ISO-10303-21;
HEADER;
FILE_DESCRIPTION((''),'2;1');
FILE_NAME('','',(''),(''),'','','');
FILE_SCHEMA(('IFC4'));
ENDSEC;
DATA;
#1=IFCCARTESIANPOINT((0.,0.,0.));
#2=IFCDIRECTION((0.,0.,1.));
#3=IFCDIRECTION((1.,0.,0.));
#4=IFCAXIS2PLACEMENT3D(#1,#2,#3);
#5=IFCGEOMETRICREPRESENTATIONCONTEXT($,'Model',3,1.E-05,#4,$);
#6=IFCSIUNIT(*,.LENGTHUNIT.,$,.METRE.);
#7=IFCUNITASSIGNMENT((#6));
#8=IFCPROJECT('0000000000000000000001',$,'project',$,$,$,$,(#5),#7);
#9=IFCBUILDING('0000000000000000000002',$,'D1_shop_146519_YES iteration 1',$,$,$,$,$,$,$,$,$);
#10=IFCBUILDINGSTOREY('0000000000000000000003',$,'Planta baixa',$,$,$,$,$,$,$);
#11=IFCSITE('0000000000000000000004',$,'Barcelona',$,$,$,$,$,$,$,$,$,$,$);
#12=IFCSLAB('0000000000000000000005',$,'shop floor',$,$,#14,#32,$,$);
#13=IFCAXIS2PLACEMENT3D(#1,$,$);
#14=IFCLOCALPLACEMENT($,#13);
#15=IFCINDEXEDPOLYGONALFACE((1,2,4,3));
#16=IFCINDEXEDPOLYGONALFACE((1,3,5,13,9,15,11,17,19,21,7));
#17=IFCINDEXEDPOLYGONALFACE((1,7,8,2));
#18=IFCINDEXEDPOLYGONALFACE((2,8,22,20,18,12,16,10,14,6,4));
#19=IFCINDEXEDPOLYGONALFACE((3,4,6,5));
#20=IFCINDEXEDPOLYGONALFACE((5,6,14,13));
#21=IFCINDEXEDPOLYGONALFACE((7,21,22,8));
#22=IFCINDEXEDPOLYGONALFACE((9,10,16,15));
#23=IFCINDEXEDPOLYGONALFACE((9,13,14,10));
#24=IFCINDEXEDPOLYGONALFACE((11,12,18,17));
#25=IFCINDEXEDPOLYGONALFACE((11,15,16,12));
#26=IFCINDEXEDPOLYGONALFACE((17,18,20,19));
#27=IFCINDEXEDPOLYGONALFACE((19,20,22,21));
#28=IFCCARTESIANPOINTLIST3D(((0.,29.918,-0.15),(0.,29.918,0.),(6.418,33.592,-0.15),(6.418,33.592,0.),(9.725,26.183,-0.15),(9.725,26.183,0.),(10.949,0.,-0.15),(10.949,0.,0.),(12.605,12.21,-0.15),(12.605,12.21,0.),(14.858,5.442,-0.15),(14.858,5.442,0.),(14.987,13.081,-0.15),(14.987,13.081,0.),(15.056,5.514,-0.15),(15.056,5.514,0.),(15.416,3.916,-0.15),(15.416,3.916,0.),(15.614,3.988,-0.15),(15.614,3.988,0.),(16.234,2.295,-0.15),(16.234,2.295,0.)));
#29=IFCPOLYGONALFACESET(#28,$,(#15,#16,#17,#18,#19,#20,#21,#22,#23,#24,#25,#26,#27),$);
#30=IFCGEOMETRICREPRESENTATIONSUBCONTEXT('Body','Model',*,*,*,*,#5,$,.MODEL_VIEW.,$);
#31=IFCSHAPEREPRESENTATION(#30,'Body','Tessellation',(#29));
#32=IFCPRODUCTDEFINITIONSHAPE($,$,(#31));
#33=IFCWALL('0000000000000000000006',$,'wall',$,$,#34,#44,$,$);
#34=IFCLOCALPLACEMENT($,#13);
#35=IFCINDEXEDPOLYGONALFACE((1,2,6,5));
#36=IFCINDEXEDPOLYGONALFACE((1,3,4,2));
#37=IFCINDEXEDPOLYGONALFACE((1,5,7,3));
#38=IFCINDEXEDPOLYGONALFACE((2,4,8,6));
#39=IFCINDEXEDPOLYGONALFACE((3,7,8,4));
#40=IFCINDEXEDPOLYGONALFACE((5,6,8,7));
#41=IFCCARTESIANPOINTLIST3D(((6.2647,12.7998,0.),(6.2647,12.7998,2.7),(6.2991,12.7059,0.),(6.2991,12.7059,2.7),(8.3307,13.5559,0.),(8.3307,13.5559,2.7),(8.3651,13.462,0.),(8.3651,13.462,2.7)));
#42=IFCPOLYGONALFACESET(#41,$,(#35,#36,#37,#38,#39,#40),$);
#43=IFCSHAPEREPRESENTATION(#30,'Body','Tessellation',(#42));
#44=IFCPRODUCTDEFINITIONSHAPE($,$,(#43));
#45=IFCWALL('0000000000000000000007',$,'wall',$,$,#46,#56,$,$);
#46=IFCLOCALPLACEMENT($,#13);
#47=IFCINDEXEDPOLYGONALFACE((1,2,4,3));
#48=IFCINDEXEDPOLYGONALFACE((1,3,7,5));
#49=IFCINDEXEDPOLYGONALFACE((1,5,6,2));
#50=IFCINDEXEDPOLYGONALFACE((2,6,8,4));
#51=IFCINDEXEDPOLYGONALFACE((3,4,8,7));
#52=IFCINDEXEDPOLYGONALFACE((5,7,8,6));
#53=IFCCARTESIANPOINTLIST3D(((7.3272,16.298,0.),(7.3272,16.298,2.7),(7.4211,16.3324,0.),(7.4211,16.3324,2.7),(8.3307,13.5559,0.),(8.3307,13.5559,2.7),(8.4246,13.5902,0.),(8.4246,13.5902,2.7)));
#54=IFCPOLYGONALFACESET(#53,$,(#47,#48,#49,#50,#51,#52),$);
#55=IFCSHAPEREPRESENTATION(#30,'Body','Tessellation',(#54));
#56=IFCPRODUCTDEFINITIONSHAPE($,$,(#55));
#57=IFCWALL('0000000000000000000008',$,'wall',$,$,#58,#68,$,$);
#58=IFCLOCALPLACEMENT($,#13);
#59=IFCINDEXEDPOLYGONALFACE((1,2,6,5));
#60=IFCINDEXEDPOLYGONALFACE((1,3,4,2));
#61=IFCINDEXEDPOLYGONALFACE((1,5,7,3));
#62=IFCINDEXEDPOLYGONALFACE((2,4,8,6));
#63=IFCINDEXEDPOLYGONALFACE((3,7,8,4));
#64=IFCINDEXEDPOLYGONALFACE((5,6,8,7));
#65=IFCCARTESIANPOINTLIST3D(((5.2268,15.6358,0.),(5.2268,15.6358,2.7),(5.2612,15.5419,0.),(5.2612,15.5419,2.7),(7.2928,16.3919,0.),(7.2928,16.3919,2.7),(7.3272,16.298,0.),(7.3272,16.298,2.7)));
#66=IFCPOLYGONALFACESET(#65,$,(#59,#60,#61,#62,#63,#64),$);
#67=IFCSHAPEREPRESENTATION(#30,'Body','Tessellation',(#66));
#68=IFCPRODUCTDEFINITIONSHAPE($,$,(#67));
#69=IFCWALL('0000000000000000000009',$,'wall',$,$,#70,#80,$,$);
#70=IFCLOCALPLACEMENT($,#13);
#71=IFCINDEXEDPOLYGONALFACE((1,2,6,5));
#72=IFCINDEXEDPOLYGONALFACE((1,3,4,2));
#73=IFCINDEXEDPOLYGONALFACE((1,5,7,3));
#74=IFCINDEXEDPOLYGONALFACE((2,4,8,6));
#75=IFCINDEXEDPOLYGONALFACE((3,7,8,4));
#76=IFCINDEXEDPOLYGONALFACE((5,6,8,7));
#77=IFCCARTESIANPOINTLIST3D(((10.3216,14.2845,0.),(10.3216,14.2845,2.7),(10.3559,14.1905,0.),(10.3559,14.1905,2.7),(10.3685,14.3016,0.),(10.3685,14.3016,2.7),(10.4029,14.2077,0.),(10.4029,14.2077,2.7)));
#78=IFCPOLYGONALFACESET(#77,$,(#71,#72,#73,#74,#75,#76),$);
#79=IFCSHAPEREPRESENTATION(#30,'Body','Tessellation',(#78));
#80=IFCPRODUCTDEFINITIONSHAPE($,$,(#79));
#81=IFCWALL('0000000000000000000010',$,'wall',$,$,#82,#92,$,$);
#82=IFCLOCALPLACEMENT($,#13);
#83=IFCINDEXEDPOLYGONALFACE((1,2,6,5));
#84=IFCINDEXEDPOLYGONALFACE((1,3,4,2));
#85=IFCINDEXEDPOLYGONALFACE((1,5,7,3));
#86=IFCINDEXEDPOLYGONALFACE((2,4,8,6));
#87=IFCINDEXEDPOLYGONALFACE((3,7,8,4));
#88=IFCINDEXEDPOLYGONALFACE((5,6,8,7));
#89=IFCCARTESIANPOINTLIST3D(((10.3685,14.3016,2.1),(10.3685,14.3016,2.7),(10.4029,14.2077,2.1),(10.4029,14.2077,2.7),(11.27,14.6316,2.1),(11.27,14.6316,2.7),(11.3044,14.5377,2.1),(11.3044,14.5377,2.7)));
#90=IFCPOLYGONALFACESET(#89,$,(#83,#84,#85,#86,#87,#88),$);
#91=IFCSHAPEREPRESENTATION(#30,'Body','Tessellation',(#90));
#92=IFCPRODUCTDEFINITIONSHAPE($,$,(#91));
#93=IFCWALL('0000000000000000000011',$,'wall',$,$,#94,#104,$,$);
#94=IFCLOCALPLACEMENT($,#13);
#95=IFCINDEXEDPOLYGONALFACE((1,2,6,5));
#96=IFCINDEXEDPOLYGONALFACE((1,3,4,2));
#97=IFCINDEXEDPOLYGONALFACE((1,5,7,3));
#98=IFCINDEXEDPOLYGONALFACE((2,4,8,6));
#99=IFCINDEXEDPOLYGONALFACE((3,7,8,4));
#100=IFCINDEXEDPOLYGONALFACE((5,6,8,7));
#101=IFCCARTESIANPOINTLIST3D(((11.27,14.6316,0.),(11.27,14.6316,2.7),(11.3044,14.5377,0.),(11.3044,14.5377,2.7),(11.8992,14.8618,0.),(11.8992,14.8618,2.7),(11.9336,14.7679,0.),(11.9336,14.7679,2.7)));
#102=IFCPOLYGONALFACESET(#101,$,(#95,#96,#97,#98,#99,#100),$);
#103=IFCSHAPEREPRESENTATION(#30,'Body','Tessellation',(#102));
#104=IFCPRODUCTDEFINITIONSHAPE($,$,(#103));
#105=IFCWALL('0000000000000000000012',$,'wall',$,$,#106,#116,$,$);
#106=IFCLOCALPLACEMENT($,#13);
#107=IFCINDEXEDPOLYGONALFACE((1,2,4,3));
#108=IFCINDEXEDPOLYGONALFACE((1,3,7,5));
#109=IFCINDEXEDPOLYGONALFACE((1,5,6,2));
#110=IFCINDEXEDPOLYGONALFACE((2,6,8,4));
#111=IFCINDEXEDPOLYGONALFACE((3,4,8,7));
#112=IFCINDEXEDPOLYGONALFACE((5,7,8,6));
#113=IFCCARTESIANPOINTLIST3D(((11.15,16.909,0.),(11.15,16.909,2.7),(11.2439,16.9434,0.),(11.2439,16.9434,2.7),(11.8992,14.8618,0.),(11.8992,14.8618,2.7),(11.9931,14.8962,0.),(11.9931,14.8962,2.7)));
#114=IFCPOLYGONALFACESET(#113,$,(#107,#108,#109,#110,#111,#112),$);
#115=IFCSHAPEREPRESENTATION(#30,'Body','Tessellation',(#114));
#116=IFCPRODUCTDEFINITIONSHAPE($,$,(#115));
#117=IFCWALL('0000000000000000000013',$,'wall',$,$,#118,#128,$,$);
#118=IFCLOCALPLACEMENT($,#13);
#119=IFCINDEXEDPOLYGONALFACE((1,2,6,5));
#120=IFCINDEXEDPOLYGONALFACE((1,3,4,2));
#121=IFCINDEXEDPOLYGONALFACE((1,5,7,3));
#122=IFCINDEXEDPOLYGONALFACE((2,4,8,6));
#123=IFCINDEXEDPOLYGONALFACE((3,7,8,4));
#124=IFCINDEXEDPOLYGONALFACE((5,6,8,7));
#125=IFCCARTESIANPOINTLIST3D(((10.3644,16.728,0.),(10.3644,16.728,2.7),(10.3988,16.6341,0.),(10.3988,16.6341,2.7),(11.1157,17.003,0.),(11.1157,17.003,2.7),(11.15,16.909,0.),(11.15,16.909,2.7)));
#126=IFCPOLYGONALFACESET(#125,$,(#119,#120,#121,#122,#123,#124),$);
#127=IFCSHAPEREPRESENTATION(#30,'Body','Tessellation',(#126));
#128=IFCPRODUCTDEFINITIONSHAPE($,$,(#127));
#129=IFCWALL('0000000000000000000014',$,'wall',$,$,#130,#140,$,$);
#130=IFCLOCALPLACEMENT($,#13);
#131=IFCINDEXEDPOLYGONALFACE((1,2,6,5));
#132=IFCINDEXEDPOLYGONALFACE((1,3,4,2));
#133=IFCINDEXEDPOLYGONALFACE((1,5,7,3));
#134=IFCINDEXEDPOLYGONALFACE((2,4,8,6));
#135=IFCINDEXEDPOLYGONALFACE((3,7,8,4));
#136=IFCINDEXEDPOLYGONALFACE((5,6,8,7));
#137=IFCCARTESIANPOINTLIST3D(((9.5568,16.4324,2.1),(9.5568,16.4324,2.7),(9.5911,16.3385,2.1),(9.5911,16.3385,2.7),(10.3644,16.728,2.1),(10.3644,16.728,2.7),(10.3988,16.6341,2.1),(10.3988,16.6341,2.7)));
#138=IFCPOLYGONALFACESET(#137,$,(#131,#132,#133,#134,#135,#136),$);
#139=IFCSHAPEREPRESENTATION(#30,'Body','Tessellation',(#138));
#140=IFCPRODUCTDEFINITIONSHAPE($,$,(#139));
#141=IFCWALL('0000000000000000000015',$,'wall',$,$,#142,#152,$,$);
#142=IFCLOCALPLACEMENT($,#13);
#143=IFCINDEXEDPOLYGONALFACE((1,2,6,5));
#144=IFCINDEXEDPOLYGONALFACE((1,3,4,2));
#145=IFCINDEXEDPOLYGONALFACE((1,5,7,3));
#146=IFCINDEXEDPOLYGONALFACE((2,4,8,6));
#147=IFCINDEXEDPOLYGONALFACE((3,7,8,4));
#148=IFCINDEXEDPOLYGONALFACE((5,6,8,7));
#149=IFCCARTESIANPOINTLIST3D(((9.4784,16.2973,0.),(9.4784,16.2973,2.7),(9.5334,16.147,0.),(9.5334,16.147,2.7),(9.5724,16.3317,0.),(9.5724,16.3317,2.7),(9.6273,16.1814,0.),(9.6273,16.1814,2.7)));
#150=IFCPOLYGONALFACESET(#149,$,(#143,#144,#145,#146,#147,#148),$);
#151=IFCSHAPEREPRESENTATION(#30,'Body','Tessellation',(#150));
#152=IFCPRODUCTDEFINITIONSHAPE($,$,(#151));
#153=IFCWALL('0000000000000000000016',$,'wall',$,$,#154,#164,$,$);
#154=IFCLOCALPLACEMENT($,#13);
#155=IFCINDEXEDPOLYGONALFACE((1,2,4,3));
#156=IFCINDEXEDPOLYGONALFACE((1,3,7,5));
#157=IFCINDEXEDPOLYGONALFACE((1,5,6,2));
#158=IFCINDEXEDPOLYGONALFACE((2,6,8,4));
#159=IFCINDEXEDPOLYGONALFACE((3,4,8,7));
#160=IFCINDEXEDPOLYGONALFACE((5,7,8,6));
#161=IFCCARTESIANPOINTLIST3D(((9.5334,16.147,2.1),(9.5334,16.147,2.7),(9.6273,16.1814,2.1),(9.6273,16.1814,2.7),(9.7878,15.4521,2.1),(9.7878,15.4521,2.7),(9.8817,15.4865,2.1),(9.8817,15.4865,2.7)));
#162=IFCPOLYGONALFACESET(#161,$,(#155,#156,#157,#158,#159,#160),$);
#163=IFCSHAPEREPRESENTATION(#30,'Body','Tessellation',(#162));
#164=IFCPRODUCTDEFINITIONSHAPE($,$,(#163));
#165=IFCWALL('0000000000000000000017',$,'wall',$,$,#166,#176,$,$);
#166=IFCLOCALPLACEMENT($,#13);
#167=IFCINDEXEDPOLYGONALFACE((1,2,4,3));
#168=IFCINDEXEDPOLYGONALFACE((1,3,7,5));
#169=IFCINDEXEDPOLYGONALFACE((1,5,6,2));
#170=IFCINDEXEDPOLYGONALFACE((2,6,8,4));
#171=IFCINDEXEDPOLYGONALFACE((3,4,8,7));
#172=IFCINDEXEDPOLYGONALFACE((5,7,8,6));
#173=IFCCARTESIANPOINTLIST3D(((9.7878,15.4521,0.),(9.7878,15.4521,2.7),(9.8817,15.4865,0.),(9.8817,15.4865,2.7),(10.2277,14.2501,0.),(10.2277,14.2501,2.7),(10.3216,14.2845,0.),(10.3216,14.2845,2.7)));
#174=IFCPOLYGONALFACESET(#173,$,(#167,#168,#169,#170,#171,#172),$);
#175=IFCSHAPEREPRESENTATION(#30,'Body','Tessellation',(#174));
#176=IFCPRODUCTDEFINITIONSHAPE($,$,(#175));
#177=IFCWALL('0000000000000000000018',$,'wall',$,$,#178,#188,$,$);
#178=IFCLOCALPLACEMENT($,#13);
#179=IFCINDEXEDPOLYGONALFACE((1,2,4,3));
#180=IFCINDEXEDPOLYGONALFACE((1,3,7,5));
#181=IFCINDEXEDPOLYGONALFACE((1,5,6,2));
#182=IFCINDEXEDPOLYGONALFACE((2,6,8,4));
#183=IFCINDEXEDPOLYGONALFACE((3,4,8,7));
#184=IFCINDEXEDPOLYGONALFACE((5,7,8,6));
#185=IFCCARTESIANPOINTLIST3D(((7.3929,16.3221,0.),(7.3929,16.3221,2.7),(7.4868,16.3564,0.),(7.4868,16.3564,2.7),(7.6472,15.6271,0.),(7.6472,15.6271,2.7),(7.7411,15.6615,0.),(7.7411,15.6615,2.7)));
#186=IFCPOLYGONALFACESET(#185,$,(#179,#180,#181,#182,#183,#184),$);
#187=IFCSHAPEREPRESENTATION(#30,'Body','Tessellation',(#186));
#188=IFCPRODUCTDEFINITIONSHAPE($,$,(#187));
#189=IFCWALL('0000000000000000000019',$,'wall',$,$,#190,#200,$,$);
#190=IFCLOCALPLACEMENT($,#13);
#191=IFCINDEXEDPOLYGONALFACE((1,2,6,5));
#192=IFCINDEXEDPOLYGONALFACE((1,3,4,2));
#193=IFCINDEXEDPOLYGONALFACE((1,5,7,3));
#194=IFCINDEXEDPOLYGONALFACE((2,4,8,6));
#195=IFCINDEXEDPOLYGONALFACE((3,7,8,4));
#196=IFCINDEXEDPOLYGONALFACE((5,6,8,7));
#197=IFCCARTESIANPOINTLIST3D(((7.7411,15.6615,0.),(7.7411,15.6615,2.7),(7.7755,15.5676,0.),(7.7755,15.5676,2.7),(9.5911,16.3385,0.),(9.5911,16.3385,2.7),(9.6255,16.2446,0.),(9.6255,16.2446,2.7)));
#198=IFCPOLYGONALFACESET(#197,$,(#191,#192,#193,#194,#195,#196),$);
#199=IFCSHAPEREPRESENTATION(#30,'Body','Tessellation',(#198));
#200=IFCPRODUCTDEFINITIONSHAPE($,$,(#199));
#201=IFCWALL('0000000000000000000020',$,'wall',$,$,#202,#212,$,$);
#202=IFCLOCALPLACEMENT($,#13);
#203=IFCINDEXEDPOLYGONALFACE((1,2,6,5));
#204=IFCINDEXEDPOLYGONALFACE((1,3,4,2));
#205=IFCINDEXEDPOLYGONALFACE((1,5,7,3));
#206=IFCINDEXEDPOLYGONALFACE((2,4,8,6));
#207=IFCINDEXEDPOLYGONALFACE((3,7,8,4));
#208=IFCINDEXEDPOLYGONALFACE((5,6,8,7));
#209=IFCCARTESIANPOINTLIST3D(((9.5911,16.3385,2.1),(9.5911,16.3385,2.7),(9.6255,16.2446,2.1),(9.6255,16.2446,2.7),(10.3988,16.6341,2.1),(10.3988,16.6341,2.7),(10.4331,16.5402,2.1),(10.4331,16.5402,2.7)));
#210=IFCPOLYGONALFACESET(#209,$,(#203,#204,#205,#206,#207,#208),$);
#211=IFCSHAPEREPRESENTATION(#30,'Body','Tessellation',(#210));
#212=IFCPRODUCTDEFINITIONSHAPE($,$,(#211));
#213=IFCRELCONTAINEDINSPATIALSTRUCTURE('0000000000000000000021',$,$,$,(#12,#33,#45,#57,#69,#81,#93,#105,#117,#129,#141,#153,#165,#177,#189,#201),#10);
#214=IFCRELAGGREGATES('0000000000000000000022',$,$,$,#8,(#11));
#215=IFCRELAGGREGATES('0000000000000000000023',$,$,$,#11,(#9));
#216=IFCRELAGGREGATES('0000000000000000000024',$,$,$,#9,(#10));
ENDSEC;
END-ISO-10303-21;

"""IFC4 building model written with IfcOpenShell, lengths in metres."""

from ifc_helpers import new_model, si_unit, frame, origin, origin_with_axes, place, context, subcontext, project, spatial, polyline, outline, extrude, element, save


model = new_model("IFC4")

# Units and contexts
model_context = context("Model", 3, precision=1e-05, world=origin_with_axes())
body_context = subcontext(model_context, "Body", "Model", "MODEL_VIEW")
ifc_project = project(units=[si_unit("LENGTHUNIT", "METRE")], contexts=[model_context])

# Site, building, storey
site = spatial("IfcSite", under=ifc_project, Name="Barcelona")
building = spatial("IfcBuilding", under=site, Name="D1_shop_146519_YES iteration 1")
storey = spatial("IfcBuildingStorey", under=building, Name="Planta baixa")

# Slab
slab_placement = place(None, origin_with_axes())
element("IfcSlab", 1, at=slab_placement, inside=storey, Name="shop floor", context=body_context, shape_type="SweptSolid", body=[
    extrude(outline(polyline([(10.949, 0.0), (0.0, 29.918), (6.418, 33.592), (9.725, 26.183), (14.987, 13.081), (12.605, 12.21), (15.056, 5.514), (14.858, 5.442), (15.416, 3.916), (15.614, 3.988), (16.234, 2.295), (10.949, 0.0)])), frame((0.0, 0.0, -0.15)), (0.0, 0.0, 1.0), 0.15),
])

# Walls
wall_1_placement = place(None, origin_with_axes())
element("IfcWall", 2, at=wall_1_placement, inside=storey, Name="wall", context=body_context, shape_type="SweptSolid", body=[
    extrude(outline(polyline([(6.2647, 12.7998), (8.3307, 13.5559), (8.3651, 13.462), (6.2991, 12.7059), (6.2647, 12.7998)])), origin(), (0.0, 0.0, 1.0), 2.7),
])
wall_2_placement = place(None, origin_with_axes())
element("IfcWall", 3, at=wall_2_placement, inside=storey, Name="wall", context=body_context, shape_type="SweptSolid", body=[
    extrude(outline(polyline([(8.3307, 13.5559), (7.3272, 16.298), (7.4211, 16.3324), (8.4246, 13.5902), (8.3307, 13.5559)])), origin(), (0.0, 0.0, 1.0), 2.7),
])
wall_3_placement = place(None, origin_with_axes())
element("IfcWall", 4, at=wall_3_placement, inside=storey, Name="wall", context=body_context, shape_type="SweptSolid", body=[
    extrude(outline(polyline([(7.3272, 16.298), (5.2612, 15.5419), (5.2268, 15.6358), (7.2928, 16.3919), (7.3272, 16.298)])), origin(), (0.0, 0.0, 1.0), 2.7),
])
wall_4_placement = place(None, origin_with_axes())
element("IfcWall", 5, at=wall_4_placement, inside=storey, Name="wall", context=body_context, shape_type="SweptSolid", body=[
    extrude(outline(polyline([(10.3216, 14.2845), (10.3685, 14.3016), (10.4029, 14.2077), (10.3559, 14.1905), (10.3216, 14.2845)])), origin(), (0.0, 0.0, 1.0), 2.7),
])
wall_5_placement = place(None, origin_with_axes())
element("IfcWall", 6, at=wall_5_placement, inside=storey, Name="wall", context=body_context, shape_type="SweptSolid", body=[
    extrude(outline(polyline([(10.3685, 14.3016), (11.27, 14.6316), (11.3044, 14.5377), (10.4029, 14.2077), (10.3685, 14.3016)])), frame((0.0, 0.0, 2.1)), (0.0, 0.0, 1.0), 0.6),
])
wall_6_placement = place(None, origin_with_axes())
element("IfcWall", 7, at=wall_6_placement, inside=storey, Name="wall", context=body_context, shape_type="SweptSolid", body=[
    extrude(outline(polyline([(11.27, 14.6316), (11.8992, 14.8618), (11.9336, 14.7679), (11.3044, 14.5377), (11.27, 14.6316)])), origin(), (0.0, 0.0, 1.0), 2.7),
])
wall_7_placement = place(None, origin_with_axes())
element("IfcWall", 8, at=wall_7_placement, inside=storey, Name="wall", context=body_context, shape_type="SweptSolid", body=[
    extrude(outline(polyline([(11.8992, 14.8618), (11.15, 16.909), (11.2439, 16.9434), (11.9931, 14.8962), (11.8992, 14.8618)])), origin(), (0.0, 0.0, 1.0), 2.7),
])
wall_8_placement = place(None, origin_with_axes())
element("IfcWall", 9, at=wall_8_placement, inside=storey, Name="wall", context=body_context, shape_type="SweptSolid", body=[
    extrude(outline(polyline([(11.15, 16.909), (10.3988, 16.6341), (10.3644, 16.728), (11.1157, 17.003), (11.15, 16.909)])), origin(), (0.0, 0.0, 1.0), 2.7),
])
wall_9_placement = place(None, origin_with_axes())
element("IfcWall", 10, at=wall_9_placement, inside=storey, Name="wall", context=body_context, shape_type="SweptSolid", body=[
    extrude(outline(polyline([(10.3988, 16.6341), (9.5911, 16.3385), (9.5568, 16.4324), (10.3644, 16.728), (10.3988, 16.6341)])), frame((0.0, 0.0, 2.1)), (0.0, 0.0, 1.0), 0.6),
])
wall_10_placement = place(None, origin_with_axes())
element("IfcWall", 11, at=wall_10_placement, inside=storey, Name="wall", context=body_context, shape_type="SweptSolid", body=[
    extrude(outline(polyline([(9.5724, 16.3317), (9.6273, 16.1814), (9.5334, 16.147), (9.4784, 16.2973), (9.5724, 16.3317)])), origin(), (0.0, 0.0, 1.0), 2.7),
])
wall_11_placement = place(None, origin_with_axes())
element("IfcWall", 12, at=wall_11_placement, inside=storey, Name="wall", context=body_context, shape_type="SweptSolid", body=[
    extrude(outline(polyline([(9.6273, 16.1814), (9.8817, 15.4865), (9.7878, 15.4521), (9.5334, 16.147), (9.6273, 16.1814)])), frame((0.0, 0.0, 2.1)), (0.0, 0.0, 1.0), 0.6),
])
wall_12_placement = place(None, origin_with_axes())
element("IfcWall", 13, at=wall_12_placement, inside=storey, Name="wall", context=body_context, shape_type="SweptSolid", body=[
    extrude(outline(polyline([(9.8817, 15.4865), (10.3216, 14.2845), (10.2277, 14.2501), (9.7878, 15.4521), (9.8817, 15.4865)])), origin(), (0.0, 0.0, 1.0), 2.7),
])
wall_13_placement = place(None, origin_with_axes())
element("IfcWall", 14, at=wall_13_placement, inside=storey, Name="wall", context=body_context, shape_type="SweptSolid", body=[
    extrude(outline(polyline([(7.4868, 16.3564), (7.7411, 15.6615), (7.6472, 15.6271), (7.3929, 16.3221), (7.4868, 16.3564)])), origin(), (0.0, 0.0, 1.0), 2.7),
])
wall_14_placement = place(None, origin_with_axes())
element("IfcWall", 15, at=wall_14_placement, inside=storey, Name="wall", context=body_context, shape_type="SweptSolid", body=[
    extrude(outline(polyline([(7.7411, 15.6615), (9.5911, 16.3385), (9.6255, 16.2446), (7.7755, 15.5676), (7.7411, 15.6615)])), origin(), (0.0, 0.0, 1.0), 2.7),
])
wall_15_placement = place(None, origin_with_axes())
element("IfcWall", 16, at=wall_15_placement, inside=storey, Name="wall", context=body_context, shape_type="SweptSolid", body=[
    extrude(outline(polyline([(9.5911, 16.3385), (10.3988, 16.6341), (10.4331, 16.5402), (9.6255, 16.2446), (9.5911, 16.3385)])), frame((0.0, 0.0, 2.1)), (0.0, 0.0, 1.0), 0.6),
])

save(model, "model.ifc")
